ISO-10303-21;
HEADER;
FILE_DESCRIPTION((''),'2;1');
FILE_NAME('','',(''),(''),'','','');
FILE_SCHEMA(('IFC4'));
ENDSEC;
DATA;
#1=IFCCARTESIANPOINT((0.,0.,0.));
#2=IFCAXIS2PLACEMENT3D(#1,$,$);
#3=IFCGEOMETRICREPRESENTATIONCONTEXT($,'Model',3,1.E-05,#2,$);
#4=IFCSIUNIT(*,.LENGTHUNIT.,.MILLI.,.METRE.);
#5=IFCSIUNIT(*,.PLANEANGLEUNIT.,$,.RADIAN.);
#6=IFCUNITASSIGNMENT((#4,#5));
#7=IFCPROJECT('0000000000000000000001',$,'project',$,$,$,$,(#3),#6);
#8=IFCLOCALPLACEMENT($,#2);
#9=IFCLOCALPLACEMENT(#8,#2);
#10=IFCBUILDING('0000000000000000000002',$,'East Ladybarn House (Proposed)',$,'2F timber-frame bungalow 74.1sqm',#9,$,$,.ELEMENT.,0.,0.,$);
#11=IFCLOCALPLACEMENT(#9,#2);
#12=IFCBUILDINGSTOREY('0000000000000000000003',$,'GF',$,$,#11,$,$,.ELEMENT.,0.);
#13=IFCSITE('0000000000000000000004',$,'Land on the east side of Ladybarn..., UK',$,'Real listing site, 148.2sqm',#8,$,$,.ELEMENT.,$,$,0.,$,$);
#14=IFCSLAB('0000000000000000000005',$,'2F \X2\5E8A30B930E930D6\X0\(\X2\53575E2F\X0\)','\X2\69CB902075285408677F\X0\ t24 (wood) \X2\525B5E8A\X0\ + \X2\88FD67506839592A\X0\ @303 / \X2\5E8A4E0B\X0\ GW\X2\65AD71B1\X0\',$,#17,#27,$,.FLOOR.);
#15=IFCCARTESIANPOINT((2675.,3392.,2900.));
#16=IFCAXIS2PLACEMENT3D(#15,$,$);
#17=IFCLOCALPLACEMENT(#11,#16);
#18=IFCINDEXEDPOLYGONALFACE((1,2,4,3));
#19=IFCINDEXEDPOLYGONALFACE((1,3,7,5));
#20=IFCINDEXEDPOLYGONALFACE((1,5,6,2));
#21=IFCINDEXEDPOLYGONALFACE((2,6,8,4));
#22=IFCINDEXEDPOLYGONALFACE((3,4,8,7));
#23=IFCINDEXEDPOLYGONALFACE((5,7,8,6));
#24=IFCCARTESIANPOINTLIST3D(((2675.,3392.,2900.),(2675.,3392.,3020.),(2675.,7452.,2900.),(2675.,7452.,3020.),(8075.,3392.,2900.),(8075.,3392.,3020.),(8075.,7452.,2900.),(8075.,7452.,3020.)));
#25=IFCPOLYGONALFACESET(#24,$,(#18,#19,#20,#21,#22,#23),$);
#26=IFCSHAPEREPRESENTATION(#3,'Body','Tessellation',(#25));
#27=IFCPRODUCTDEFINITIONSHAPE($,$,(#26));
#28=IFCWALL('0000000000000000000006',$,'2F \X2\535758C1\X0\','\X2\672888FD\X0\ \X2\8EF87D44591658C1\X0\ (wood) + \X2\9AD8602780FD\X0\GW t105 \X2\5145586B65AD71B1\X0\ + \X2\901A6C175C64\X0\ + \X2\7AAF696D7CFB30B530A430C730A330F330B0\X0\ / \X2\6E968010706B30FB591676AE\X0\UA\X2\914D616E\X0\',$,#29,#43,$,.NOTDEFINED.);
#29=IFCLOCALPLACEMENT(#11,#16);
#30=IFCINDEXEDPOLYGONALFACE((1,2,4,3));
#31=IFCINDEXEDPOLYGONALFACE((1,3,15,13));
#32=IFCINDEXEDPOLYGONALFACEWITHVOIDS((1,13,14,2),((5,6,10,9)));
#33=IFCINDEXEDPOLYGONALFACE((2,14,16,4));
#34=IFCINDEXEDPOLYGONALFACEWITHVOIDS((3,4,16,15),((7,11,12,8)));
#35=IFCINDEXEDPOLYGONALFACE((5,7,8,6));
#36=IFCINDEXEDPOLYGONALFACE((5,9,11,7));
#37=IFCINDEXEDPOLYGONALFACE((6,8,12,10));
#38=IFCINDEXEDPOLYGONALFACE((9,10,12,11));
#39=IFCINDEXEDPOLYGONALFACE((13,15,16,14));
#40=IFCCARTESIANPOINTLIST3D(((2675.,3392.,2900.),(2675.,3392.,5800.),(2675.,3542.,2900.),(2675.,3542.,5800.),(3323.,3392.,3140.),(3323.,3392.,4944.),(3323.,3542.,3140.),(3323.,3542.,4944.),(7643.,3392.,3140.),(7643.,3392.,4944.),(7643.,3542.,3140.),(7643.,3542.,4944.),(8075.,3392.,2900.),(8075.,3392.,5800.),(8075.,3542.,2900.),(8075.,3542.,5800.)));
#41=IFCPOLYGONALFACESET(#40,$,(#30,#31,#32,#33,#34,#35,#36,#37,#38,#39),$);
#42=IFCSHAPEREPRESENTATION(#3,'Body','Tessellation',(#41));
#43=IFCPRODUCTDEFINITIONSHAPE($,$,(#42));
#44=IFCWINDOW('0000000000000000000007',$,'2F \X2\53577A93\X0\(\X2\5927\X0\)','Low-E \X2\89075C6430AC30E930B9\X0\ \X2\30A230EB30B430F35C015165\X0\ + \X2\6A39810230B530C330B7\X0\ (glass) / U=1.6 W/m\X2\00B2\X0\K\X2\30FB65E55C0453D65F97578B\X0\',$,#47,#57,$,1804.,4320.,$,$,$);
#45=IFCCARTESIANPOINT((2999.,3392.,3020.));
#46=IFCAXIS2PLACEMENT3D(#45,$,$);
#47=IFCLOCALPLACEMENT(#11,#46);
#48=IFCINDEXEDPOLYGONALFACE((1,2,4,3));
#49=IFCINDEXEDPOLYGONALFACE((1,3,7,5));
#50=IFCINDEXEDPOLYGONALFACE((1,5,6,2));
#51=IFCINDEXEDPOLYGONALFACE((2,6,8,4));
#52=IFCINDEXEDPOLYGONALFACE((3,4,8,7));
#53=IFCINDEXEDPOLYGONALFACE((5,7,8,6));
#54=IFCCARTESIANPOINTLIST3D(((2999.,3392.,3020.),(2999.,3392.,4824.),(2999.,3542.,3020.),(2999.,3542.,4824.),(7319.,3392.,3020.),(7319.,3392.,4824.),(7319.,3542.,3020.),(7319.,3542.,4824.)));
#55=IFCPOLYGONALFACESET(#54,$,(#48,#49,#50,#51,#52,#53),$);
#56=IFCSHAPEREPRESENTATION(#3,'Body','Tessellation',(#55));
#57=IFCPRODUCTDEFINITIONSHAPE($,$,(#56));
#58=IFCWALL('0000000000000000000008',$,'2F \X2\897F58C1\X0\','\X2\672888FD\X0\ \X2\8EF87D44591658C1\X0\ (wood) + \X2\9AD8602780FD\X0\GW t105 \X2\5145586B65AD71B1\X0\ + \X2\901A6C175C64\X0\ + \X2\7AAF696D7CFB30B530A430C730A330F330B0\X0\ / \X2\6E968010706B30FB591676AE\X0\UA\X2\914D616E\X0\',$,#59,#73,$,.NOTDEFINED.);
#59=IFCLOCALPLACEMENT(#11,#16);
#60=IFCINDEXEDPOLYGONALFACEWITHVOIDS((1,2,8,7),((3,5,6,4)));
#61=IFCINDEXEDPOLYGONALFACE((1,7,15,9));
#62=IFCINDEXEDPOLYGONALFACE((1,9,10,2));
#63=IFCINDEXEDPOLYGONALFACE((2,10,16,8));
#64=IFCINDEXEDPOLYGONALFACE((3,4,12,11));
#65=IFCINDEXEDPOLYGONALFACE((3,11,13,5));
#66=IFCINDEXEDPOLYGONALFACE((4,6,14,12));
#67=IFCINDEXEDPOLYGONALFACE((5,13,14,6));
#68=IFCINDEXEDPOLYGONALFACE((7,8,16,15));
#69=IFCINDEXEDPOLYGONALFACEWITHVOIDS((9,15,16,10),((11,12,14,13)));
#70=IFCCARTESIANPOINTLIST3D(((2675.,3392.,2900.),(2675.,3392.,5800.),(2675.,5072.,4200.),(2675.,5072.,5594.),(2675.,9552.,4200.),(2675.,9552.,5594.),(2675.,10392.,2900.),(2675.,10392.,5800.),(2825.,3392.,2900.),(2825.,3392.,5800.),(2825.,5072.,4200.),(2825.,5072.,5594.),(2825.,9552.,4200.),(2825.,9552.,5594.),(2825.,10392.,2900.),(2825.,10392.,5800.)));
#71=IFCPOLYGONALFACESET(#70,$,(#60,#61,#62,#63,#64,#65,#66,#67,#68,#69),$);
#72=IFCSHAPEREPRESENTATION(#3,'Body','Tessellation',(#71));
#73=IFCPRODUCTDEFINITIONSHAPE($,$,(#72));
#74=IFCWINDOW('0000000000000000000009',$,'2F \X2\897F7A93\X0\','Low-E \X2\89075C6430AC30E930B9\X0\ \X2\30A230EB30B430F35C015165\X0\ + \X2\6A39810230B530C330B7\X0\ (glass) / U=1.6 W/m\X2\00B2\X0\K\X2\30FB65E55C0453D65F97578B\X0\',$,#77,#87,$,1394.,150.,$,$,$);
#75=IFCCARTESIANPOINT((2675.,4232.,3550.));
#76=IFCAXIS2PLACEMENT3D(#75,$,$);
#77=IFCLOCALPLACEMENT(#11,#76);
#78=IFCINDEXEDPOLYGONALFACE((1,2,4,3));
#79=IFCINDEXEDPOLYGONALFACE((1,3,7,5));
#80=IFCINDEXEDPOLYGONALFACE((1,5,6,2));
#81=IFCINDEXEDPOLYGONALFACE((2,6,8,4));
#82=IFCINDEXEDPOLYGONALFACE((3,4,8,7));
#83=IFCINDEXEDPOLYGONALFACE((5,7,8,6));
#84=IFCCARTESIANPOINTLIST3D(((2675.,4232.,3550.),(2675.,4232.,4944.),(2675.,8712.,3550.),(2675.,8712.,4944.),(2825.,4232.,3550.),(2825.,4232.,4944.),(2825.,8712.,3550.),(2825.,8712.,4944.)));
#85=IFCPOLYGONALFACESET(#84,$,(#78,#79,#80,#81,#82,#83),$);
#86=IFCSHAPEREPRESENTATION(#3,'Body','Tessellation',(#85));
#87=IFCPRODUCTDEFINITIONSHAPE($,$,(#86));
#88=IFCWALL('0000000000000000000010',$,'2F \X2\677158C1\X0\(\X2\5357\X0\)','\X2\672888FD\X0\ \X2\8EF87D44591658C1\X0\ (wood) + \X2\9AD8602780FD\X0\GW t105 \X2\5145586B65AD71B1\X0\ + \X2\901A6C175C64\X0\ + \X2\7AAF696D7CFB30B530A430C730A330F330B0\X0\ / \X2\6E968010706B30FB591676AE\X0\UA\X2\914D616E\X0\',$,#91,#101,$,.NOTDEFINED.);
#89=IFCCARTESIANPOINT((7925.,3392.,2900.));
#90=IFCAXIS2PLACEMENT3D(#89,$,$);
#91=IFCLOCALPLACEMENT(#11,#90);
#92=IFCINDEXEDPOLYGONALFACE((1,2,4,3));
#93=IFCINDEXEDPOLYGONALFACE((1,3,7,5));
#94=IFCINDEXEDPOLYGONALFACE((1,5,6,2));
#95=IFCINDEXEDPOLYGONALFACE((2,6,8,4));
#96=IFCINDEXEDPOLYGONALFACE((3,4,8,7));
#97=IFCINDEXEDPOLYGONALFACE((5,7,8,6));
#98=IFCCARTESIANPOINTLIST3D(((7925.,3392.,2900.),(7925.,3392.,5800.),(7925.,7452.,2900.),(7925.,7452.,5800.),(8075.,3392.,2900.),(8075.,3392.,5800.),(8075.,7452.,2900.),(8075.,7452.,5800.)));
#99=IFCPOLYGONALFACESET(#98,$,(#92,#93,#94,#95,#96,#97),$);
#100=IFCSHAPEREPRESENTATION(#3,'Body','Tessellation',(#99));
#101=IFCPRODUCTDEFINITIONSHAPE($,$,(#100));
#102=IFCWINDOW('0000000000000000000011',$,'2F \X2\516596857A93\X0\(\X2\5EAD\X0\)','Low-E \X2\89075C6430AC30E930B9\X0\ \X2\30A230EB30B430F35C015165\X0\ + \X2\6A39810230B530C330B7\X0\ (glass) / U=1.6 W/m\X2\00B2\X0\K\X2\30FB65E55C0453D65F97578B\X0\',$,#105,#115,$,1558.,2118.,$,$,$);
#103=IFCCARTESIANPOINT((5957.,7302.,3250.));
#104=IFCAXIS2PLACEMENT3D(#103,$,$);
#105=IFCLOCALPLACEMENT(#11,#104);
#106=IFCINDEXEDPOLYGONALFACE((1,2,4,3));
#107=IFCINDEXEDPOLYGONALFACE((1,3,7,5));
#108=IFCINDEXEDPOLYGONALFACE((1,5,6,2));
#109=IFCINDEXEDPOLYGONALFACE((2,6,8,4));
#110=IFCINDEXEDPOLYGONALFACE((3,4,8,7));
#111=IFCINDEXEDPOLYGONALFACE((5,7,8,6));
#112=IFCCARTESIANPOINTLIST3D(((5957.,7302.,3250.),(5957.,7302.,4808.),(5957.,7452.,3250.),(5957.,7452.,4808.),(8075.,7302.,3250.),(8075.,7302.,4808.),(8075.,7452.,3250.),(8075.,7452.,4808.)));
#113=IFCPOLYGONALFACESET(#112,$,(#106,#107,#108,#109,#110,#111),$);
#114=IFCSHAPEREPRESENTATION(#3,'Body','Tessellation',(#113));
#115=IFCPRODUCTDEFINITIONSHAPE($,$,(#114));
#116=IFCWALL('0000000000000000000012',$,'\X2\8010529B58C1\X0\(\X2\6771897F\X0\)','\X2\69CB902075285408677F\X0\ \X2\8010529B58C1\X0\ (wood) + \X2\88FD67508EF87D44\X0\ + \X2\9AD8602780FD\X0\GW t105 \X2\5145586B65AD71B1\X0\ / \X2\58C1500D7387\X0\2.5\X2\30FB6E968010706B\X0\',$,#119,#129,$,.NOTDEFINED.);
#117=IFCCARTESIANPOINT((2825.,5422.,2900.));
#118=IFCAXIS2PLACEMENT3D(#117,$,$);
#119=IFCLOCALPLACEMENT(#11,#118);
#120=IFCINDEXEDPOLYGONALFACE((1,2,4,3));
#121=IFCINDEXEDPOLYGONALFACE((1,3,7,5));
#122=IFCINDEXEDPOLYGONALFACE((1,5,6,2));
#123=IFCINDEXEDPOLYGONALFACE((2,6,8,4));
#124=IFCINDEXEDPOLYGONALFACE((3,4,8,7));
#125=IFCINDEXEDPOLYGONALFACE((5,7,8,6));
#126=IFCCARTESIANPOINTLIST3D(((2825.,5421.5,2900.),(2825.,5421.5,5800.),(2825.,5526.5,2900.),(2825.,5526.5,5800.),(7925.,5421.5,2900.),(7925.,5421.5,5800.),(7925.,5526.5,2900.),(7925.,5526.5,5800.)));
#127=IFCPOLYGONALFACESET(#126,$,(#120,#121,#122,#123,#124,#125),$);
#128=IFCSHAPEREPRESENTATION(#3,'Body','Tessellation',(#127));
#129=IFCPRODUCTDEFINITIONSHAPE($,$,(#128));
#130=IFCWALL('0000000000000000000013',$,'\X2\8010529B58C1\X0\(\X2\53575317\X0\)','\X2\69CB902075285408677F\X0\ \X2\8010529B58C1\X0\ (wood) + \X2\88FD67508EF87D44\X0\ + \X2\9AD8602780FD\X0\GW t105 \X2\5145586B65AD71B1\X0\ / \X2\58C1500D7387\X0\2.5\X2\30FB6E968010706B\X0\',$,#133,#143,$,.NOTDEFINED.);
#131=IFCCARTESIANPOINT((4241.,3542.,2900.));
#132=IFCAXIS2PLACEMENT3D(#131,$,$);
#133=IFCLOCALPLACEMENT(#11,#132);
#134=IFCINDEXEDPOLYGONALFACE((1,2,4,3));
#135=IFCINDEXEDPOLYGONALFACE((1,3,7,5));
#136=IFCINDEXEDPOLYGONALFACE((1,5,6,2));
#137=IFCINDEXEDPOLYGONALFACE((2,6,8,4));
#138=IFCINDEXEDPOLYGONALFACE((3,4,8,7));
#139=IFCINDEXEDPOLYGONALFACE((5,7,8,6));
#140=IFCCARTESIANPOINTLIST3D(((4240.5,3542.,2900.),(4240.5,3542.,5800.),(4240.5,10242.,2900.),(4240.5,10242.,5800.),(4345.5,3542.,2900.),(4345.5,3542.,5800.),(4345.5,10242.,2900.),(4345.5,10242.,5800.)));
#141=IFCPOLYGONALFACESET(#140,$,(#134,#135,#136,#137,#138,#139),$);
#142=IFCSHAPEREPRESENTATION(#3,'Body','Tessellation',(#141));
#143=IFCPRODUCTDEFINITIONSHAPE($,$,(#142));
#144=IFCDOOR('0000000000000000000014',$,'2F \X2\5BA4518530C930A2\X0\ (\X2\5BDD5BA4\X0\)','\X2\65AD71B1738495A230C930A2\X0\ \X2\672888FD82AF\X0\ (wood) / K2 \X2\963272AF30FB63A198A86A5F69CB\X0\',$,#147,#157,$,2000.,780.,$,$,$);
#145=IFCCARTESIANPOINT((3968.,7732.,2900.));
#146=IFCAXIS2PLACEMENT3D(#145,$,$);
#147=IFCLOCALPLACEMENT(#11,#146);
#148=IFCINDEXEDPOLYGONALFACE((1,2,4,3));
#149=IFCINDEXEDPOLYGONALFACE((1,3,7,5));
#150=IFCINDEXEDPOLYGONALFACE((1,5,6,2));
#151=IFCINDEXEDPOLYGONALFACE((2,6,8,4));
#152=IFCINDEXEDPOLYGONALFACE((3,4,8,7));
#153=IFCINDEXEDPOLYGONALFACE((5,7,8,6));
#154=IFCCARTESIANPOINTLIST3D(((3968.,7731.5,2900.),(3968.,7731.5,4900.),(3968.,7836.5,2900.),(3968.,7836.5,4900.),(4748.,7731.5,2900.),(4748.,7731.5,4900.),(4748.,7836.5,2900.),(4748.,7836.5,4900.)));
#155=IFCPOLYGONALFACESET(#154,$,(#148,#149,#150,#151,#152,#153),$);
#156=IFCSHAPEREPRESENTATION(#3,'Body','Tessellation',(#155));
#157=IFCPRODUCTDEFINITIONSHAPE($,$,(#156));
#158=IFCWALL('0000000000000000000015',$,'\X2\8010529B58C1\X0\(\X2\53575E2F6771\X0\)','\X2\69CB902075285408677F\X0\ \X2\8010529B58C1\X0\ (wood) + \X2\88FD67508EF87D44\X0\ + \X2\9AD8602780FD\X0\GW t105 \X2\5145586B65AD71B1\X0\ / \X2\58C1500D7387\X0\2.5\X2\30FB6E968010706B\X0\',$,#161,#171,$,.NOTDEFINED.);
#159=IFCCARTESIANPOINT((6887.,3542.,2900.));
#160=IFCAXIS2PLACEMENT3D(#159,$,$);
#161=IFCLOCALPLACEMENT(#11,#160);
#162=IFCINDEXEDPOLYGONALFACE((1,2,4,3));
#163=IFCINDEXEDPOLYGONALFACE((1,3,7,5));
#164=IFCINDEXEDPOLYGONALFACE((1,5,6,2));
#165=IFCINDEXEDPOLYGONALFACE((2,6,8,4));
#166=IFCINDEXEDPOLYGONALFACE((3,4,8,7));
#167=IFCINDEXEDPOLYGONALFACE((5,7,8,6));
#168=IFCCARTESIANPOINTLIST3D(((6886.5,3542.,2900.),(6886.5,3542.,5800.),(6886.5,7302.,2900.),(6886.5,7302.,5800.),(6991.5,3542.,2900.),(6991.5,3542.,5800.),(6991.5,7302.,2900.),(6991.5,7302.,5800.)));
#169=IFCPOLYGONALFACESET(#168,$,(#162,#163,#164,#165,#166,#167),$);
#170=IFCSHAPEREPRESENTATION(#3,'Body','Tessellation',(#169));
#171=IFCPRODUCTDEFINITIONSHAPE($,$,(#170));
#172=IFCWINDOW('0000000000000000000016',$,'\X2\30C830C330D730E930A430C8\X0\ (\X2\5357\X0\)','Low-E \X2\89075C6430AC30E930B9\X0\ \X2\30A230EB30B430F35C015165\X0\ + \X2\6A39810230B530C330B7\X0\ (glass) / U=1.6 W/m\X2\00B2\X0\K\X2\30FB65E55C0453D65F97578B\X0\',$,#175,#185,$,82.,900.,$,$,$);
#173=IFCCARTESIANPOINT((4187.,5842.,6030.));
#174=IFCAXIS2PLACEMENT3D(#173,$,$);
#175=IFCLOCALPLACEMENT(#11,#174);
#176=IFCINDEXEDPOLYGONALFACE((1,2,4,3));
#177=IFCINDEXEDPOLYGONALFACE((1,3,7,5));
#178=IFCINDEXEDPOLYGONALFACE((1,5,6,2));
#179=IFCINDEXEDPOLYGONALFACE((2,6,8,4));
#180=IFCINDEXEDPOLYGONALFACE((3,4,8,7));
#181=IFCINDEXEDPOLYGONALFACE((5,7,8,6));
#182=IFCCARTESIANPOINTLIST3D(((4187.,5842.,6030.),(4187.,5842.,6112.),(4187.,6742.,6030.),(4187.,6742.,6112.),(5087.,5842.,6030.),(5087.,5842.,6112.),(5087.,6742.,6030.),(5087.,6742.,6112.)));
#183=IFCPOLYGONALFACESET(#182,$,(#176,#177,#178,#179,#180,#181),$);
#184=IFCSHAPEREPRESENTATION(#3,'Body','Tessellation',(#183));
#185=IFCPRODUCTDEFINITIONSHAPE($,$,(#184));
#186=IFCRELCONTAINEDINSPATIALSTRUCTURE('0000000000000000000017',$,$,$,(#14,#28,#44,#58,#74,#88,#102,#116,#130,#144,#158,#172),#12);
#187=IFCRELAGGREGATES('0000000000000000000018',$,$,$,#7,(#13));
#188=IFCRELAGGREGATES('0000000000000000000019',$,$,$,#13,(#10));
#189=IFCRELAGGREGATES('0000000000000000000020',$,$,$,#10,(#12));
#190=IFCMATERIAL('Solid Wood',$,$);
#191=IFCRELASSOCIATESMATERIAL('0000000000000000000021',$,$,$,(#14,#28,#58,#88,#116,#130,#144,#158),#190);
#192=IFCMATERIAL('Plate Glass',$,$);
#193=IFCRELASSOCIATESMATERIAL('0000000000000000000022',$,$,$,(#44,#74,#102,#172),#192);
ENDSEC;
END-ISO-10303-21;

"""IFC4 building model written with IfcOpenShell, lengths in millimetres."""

from ifc_helpers import new_model, si_unit, frame, frame_2d, origin, place, context, project, spatial, rectangle, extrude, material, element, fill, save


model = new_model("IFC4")

# Units and contexts
model_context = context("Model", 3, precision=1e-05, world=origin())
ifc_project = project(units=[si_unit("LENGTHUNIT", "METRE", prefix="MILLI"), si_unit("PLANEANGLEUNIT", "RADIAN")], contexts=[model_context])

# Site, building, storey
site_placement = place(None, origin())
site = spatial("IfcSite", under=ifc_project, at=site_placement, Name="Land on the east side of Ladybarn..., UK", ObjectType="Real listing site, 148.2sqm", CompositionType="ELEMENT", RefElevation=0.0)
building_placement = place(site_placement, origin())
building = spatial("IfcBuilding", under=site, at=building_placement, Name="East Ladybarn House (Proposed)", ObjectType="2F timber-frame bungalow 74.1sqm", CompositionType="ELEMENT", ElevationOfRefHeight=0.0, ElevationOfTerrain=0.0)
storey_placement = place(building_placement, origin())
storey = spatial("IfcBuildingStorey", under=building, at=storey_placement, Name="GF", CompositionType="ELEMENT", Elevation=0.0)

# Slab
ifc_material_1 = material(Name="Solid Wood")
slab_placement = place(storey_placement, frame((2675.0, 3392.0, 2900.0)))
element("IfcSlab", 1, at=slab_placement, inside=storey, material=ifc_material_1, Name="2F 床スラブ(南帯)", Description="構造用合板 t24 (wood) 剛床 + 製材根太 @303 / 床下 GW断熱", PredefinedType="FLOOR", context=model_context, shape_type="SweptSolid", body=[
    extrude(rectangle(XDim=5400.0, YDim=4060.0, at=frame_2d((2700.0, 2030.0))), frame((2675.0, 3392.0, 2900.0)), (0.0, 0.0, 1.0), 120.0),
])

# Walls, openings, windows
wall_1_placement = place(storey_placement, frame((2675.0, 3392.0, 2900.0)))
wall_1 = element("IfcWall", 2, at=wall_1_placement, inside=storey, material=ifc_material_1, Name="2F 南壁", Description="木製 軸組外壁 (wood) + 高性能GW t105 充填断熱 + 通気層 + 窯業系サイディング / 準耐火・外皮UA配慮", PredefinedType="NOTDEFINED", context=model_context, shape_type="SweptSolid", body=[
    extrude(rectangle(XDim=5400.0, YDim=150.0, at=frame_2d((2700.0, 75.0))), frame((2675.0, 3392.0, 2900.0)), (0.0, 0.0, 1.0), 2900.0),
])
opening_1_placement = place(storey_placement, frame((2999.0, 3392.0, 3020.0)))
opening_1 = element("IfcOpeningElement", 3, at=opening_1_placement, cuts=wall_1, PredefinedType="NOTDEFINED", context=model_context, shape_type="SweptSolid", body=[
    extrude(rectangle(XDim=4320.0, YDim=150.0, at=frame_2d((2160.0, 75.0))), frame((2999.0, 3392.0, 3020.0)), (0.0, 0.0, 1.0), 1804.0),
])
ifc_material_2 = material(Name="Plate Glass")
window_1_placement = place(storey_placement, frame((2999.0, 3392.0, 3020.0)))
window_1 = element("IfcWindow", 4, at=window_1_placement, inside=storey, material=ifc_material_2, Name="2F 南窓(大)", Description="Low-E 複層ガラス アルゴン封入 + 樹脂サッシ (glass) / U=1.6 W/m²K・日射取得型", OverallHeight=1804.0, OverallWidth=4320.0, context=model_context, shape_type="SweptSolid", body=[
    extrude(rectangle(XDim=4320.0, YDim=150.0, at=frame_2d((2160.0, 75.0))), frame((2999.0, 3392.0, 3020.0)), (0.0, 0.0, 1.0), 1804.0),
])
fill(opening_1, window_1)
wall_2_placement = place(storey_placement, frame((2675.0, 3392.0, 2900.0)))
wall_2 = element("IfcWall", 5, at=wall_2_placement, inside=storey, material=ifc_material_1, Name="2F 西壁", Description="木製 軸組外壁 (wood) + 高性能GW t105 充填断熱 + 通気層 + 窯業系サイディング / 準耐火・外皮UA配慮", PredefinedType="NOTDEFINED", context=model_context, shape_type="SweptSolid", body=[
    extrude(rectangle(XDim=150.0, YDim=7000.0, at=frame_2d((75.0, 3500.0))), frame((2675.0, 3392.0, 2900.0)), (0.0, 0.0, 1.0), 2900.0),
])
opening_2_placement = place(storey_placement, frame((2675.0, 4232.0, 3550.0)))
opening_2 = element("IfcOpeningElement", 6, at=opening_2_placement, cuts=wall_2, PredefinedType="NOTDEFINED", context=model_context, shape_type="SweptSolid", body=[
    extrude(rectangle(XDim=150.0, YDim=4480.0, at=frame_2d((75.0, 2240.0))), frame((2675.0, 4232.0, 3550.0)), (0.0, 0.0, 1.0), 1394.0),
])
window_2_placement = place(storey_placement, frame((2675.0, 4232.0, 3550.0)))
window_2 = element("IfcWindow", 7, at=window_2_placement, inside=storey, material=ifc_material_2, Name="2F 西窓", Description="Low-E 複層ガラス アルゴン封入 + 樹脂サッシ (glass) / U=1.6 W/m²K・日射取得型", OverallHeight=1394.0, OverallWidth=150.0, context=model_context, shape_type="SweptSolid", body=[
    extrude(rectangle(XDim=150.0, YDim=4480.0, at=frame_2d((75.0, 2240.0))), frame((2675.0, 4232.0, 3550.0)), (0.0, 0.0, 1.0), 1394.0),
])
fill(opening_2, window_2)
wall_3_placement = place(storey_placement, frame((7925.0, 3392.0, 2900.0)))
wall_3 = element("IfcWall", 8, at=wall_3_placement, inside=storey, material=ifc_material_1, Name="2F 東壁(南)", Description="木製 軸組外壁 (wood) + 高性能GW t105 充填断熱 + 通気層 + 窯業系サイディング / 準耐火・外皮UA配慮", PredefinedType="NOTDEFINED", context=model_context, shape_type="SweptSolid", body=[
    extrude(rectangle(XDim=150.0, YDim=4060.0, at=frame_2d((75.0, 2030.0))), frame((7925.0, 3392.0, 2900.0)), (0.0, 0.0, 1.0), 2900.0),
])
opening_3_placement = place(storey_placement, frame((5957.0, 7302.0, 3250.0)))
opening_3 = element("IfcOpeningElement", 9, at=opening_3_placement, cuts=wall_3, PredefinedType="NOTDEFINED", context=model_context, shape_type="SweptSolid", body=[
    extrude(rectangle(XDim=2118.0, YDim=150.0, at=frame_2d((1059.0, 75.0))), frame((5957.0, 7302.0, 3250.0)), (0.0, 0.0, 1.0), 1558.0),
])
window_3_placement = place(storey_placement, frame((5957.0, 7302.0, 3250.0)))
window_3 = element("IfcWindow", 10, at=window_3_placement, inside=storey, material=ifc_material_2, Name="2F 入隅窓(庭)", Description="Low-E 複層ガラス アルゴン封入 + 樹脂サッシ (glass) / U=1.6 W/m²K・日射取得型", OverallHeight=1558.0, OverallWidth=2118.0, context=model_context, shape_type="SweptSolid", body=[
    extrude(rectangle(XDim=2118.0, YDim=150.0, at=frame_2d((1059.0, 75.0))), frame((5957.0, 7302.0, 3250.0)), (0.0, 0.0, 1.0), 1558.0),
])
fill(opening_3, window_3)

# Wall
wall_4_placement = place(storey_placement, frame((2825.0, 5422.0, 2900.0)))
element("IfcWall", 11, at=wall_4_placement, inside=storey, material=ifc_material_1, Name="耐力壁(東西)", Description="構造用合板 耐力壁 (wood) + 製材軸組 + 高性能GW t105 充填断熱 / 壁倍率2.5・準耐火", PredefinedType="NOTDEFINED", context=model_context, shape_type="SweptSolid", body=[
    extrude(rectangle(XDim=5100.0, YDim=105.0, at=frame_2d((2550.0, 52.0))), frame((2825.0, 5422.0, 2900.0)), (0.0, 0.0, 1.0), 2900.0),
])

# Wall, opening, door
wall_5_placement = place(storey_placement, frame((4241.0, 3542.0, 2900.0)))
wall_5 = element("IfcWall", 12, at=wall_5_placement, inside=storey, material=ifc_material_1, Name="耐力壁(南北)", Description="構造用合板 耐力壁 (wood) + 製材軸組 + 高性能GW t105 充填断熱 / 壁倍率2.5・準耐火", PredefinedType="NOTDEFINED", context=model_context, shape_type="SweptSolid", body=[
    extrude(rectangle(XDim=105.0, YDim=6700.0, at=frame_2d((52.0, 3350.0))), frame((4241.0, 3542.0, 2900.0)), (0.0, 0.0, 1.0), 2900.0),
])
opening_4_placement = place(storey_placement, frame((3968.0, 7732.0, 2900.0)))
opening_4 = element("IfcOpeningElement", 13, at=opening_4_placement, cuts=wall_5, PredefinedType="NOTDEFINED", context=model_context, shape_type="SweptSolid", body=[
    extrude(rectangle(XDim=780.0, YDim=105.0, at=frame_2d((390.0, 52.0))), frame((3968.0, 7732.0, 2900.0)), (0.0, 0.0, 1.0), 2000.0),
])
door_placement = place(storey_placement, frame((3968.0, 7732.0, 2900.0)))
door = element("IfcDoor", 14, at=door_placement, inside=storey, material=ifc_material_1, Name="2F 室内ドア (寝室)", Description="断熱玄関ドア 木製芯 (wood) / K2 防犯・採風機構", OverallHeight=2000.0, OverallWidth=780.0, context=model_context, shape_type="SweptSolid", body=[
    extrude(rectangle(XDim=780.0, YDim=105.0, at=frame_2d((390.0, 52.0))), frame((3968.0, 7732.0, 2900.0)), (0.0, 0.0, 1.0), 2000.0),
])
fill(opening_4, door)

# Wall
wall_6_placement = place(storey_placement, frame((6887.0, 3542.0, 2900.0)))
element("IfcWall", 15, at=wall_6_placement, inside=storey, material=ifc_material_1, Name="耐力壁(南帯東)", Description="構造用合板 耐力壁 (wood) + 製材軸組 + 高性能GW t105 充填断熱 / 壁倍率2.5・準耐火", PredefinedType="NOTDEFINED", context=model_context, shape_type="SweptSolid", body=[
    extrude(rectangle(XDim=105.0, YDim=3760.0, at=frame_2d((52.0, 1880.0))), frame((6887.0, 3542.0, 2900.0)), (0.0, 0.0, 1.0), 2900.0),
])

# Window
window_4_placement = place(storey_placement, frame((4187.0, 5842.0, 6030.0)))
element("IfcWindow", 16, at=window_4_placement, inside=storey, material=ifc_material_2, Name="トップライト (南)", Description="Low-E 複層ガラス アルゴン封入 + 樹脂サッシ (glass) / U=1.6 W/m²K・日射取得型", OverallHeight=82.0, OverallWidth=900.0, context=model_context, shape_type="SweptSolid", body=[
    extrude(rectangle(XDim=900.0, YDim=900.0, at=frame_2d((450.0, 450.0))), frame((4187.0, 5842.0, 6030.0)), (0.0, 0.0, 1.0), 82.0),
])

save(model, "model.ifc")
